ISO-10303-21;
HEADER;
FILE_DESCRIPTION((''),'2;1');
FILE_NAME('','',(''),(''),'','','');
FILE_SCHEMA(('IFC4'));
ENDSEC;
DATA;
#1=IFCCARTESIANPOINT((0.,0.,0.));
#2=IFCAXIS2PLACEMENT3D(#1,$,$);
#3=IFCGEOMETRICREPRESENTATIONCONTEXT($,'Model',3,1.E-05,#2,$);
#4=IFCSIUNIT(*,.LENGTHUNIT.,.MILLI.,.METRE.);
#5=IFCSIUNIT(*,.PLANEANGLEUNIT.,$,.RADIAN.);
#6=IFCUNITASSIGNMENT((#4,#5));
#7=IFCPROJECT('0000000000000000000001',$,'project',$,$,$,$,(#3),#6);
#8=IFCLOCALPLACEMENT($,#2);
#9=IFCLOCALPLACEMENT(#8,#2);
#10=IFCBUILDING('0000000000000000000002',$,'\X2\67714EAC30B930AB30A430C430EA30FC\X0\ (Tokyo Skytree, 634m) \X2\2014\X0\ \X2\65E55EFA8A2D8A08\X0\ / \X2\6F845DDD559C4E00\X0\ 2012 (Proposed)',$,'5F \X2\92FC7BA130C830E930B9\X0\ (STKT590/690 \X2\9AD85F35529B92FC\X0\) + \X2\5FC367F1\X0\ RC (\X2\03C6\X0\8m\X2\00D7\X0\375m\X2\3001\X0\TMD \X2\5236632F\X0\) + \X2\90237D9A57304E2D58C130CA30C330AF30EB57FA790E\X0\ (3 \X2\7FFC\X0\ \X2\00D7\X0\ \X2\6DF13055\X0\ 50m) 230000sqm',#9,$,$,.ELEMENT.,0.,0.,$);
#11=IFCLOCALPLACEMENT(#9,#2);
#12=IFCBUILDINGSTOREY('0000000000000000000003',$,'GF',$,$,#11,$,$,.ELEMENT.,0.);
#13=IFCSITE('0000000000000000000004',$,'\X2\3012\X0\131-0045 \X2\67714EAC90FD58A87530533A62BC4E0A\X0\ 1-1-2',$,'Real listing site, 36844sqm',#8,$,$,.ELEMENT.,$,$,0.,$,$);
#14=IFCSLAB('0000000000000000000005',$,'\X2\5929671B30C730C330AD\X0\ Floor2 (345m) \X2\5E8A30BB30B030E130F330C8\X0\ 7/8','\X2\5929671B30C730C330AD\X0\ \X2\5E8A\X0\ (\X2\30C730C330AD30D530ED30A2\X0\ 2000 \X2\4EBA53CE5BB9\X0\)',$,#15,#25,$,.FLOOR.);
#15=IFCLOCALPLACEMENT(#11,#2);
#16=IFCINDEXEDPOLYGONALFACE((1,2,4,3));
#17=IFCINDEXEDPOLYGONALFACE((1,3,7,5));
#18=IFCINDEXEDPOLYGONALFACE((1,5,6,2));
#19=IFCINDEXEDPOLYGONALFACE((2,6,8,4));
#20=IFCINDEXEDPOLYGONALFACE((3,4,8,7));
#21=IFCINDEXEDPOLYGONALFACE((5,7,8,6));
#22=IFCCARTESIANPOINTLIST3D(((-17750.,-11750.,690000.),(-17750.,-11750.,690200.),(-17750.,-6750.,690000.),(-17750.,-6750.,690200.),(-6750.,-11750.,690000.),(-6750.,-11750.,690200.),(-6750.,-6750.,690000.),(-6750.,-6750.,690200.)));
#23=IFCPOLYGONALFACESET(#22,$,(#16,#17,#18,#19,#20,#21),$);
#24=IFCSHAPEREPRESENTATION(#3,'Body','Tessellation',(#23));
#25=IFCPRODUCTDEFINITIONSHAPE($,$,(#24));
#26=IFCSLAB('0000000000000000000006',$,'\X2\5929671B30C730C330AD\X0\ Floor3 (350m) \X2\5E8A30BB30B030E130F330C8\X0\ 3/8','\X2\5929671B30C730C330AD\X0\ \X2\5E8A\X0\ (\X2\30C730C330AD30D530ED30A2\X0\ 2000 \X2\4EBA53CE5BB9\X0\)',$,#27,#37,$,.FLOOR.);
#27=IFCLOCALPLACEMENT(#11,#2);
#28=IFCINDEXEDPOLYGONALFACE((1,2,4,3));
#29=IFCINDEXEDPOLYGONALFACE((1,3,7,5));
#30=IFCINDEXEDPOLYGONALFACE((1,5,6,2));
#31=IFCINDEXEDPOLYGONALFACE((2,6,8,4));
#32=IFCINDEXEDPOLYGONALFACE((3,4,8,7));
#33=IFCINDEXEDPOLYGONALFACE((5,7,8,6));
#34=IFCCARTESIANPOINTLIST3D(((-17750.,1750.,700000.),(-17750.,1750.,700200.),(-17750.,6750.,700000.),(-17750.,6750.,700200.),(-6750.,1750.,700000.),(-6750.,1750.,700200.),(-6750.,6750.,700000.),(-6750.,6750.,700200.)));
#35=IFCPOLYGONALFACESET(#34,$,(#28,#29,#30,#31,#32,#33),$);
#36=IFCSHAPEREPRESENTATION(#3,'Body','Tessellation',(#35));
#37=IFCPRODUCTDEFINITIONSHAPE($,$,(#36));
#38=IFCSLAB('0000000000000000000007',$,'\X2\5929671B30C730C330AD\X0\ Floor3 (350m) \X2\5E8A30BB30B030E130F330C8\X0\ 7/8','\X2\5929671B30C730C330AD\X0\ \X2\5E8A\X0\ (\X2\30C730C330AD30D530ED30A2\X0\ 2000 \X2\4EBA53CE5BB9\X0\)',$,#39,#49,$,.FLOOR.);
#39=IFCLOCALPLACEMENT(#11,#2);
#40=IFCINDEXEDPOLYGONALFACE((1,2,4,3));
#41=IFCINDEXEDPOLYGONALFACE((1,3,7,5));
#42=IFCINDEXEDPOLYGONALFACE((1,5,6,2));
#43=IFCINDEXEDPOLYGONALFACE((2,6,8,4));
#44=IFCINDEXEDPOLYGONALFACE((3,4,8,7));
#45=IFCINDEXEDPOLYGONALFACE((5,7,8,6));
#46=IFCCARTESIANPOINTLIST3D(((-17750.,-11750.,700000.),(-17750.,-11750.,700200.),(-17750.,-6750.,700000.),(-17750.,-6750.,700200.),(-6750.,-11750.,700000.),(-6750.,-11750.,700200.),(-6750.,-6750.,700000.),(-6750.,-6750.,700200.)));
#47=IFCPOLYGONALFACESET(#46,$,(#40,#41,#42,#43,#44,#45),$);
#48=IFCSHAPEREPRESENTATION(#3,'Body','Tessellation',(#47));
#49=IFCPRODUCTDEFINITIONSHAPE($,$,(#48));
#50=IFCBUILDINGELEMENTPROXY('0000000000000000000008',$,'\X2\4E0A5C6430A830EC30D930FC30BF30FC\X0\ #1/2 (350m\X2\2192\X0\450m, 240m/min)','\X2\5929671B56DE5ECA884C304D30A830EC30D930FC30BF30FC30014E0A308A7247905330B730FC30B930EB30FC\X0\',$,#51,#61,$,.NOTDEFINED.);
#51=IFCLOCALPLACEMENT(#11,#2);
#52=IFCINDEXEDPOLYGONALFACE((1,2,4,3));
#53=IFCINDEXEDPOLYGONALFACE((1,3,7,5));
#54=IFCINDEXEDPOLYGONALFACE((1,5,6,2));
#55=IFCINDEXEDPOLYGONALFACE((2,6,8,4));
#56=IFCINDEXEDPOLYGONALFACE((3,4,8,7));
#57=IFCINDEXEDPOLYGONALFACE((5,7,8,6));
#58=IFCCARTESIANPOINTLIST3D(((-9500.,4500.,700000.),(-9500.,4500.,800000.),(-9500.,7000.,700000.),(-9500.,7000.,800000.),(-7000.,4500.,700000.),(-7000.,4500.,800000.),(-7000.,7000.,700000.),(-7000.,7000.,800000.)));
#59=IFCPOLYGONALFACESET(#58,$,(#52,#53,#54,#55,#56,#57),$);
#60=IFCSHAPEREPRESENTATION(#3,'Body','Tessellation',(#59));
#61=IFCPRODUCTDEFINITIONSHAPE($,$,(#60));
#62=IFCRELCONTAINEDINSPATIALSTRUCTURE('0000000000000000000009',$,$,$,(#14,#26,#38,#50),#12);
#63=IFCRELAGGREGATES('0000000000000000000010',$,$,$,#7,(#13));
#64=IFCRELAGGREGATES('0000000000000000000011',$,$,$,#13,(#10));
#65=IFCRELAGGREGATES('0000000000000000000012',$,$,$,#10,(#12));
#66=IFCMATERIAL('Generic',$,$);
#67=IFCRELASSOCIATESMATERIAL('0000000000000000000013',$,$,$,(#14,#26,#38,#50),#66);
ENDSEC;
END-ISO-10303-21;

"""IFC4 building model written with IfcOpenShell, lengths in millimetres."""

from ifc_helpers import new_model, si_unit, frame, frame_2d, origin, place, context, project, spatial, rectangle, extrude, material, element, save


model = new_model("IFC4")

# Units and contexts
model_context = context("Model", 3, precision=1e-05, world=origin())
ifc_project = project(units=[si_unit("LENGTHUNIT", "METRE", prefix="MILLI"), si_unit("PLANEANGLEUNIT", "RADIAN")], contexts=[model_context])

# Site, building, storey
site_placement = place(None, origin())
site = spatial("IfcSite", under=ifc_project, at=site_placement, Name="〒131-0045 東京都墨田区押上 1-1-2", ObjectType="Real listing site, 36844sqm", CompositionType="ELEMENT", RefElevation=0.0)
building_placement = place(site_placement, origin())
building = spatial("IfcBuilding", under=site, at=building_placement, Name="東京スカイツリー (Tokyo Skytree, 634m) — 日建設計 / 澄川喜一 2012 (Proposed)", ObjectType="5F 鋼管トラス (STKT590/690 高張力鋼) + 心柱 RC (φ8m×375m、TMD 制振) + 連続地中壁ナックル基礎 (3 翼 × 深さ 50m) 230000sqm", CompositionType="ELEMENT", ElevationOfRefHeight=0.0, ElevationOfTerrain=0.0)
storey_placement = place(building_placement, origin())
storey = spatial("IfcBuildingStorey", under=building, at=storey_placement, Name="GF", CompositionType="ELEMENT", Elevation=0.0)

# Shared definitions
ifc_material_1 = material(Name="Generic")

# Slabs
slab_1_placement = place(storey_placement, frame((0.0, -6750.0, 345000.0), x_axis=(0.0, -1.0, 0.0)))
element("IfcSlab", 1, at=slab_1_placement, inside=storey, material=ifc_material_1, Name="天望デッキ Floor2 (345m) 床セグメント 7/8", Description="天望デッキ 床 (デッキフロア 2000 人収容)", PredefinedType="FLOOR", context=model_context, shape_type="SweptSolid", body=[
    extrude(rectangle(XDim=11000.0, YDim=5000.0, at=frame_2d((5500.0, 2500.0))), frame((0.0, -6750.0, 345000.0), x_axis=(0.0, -1.0, 0.0)), (0.0, 0.0, 1.0), 200.0),
])
slab_2_placement = place(storey_placement, frame((0.0, 6750.0, 350000.0), x_axis=(0.0, 1.0, 0.0)))
element("IfcSlab", 2, at=slab_2_placement, inside=storey, material=ifc_material_1, Name="天望デッキ Floor3 (350m) 床セグメント 3/8", Description="天望デッキ 床 (デッキフロア 2000 人収容)", PredefinedType="FLOOR", context=model_context, shape_type="SweptSolid", body=[
    extrude(rectangle(XDim=11000.0, YDim=5000.0, at=frame_2d((5500.0, 2500.0))), frame((0.0, 6750.0, 350000.0), x_axis=(0.0, 1.0, 0.0)), (0.0, 0.0, 1.0), 200.0),
])
slab_3_placement = place(storey_placement, frame((0.0, -6750.0, 350000.0), x_axis=(0.0, -1.0, 0.0)))
element("IfcSlab", 3, at=slab_3_placement, inside=storey, material=ifc_material_1, Name="天望デッキ Floor3 (350m) 床セグメント 7/8", Description="天望デッキ 床 (デッキフロア 2000 人収容)", PredefinedType="FLOOR", context=model_context, shape_type="SweptSolid", body=[
    extrude(rectangle(XDim=11000.0, YDim=5000.0, at=frame_2d((5500.0, 2500.0))), frame((0.0, -6750.0, 350000.0), x_axis=(0.0, -1.0, 0.0)), (0.0, 0.0, 1.0), 200.0),
])

# Building element proxy
proxy_placement = place(storey_placement, frame((0.0, 7000.0, 350000.0), x_axis=(0.0, 1.0, 0.0)))
element("IfcBuildingElementProxy", 4, at=proxy_placement, inside=storey, material=ifc_material_1, Name="上層エレベーター #1/2 (350m→450m, 240m/min)", Description="天望回廊行きエレベーター、上り片道シースルー", PredefinedType="NOTDEFINED", context=model_context, shape_type="SweptSolid", body=[
    extrude(rectangle(XDim=2500.0, YDim=2500.0, at=frame_2d((1250.0, 1250.0))), frame((0.0, 7000.0, 350000.0), x_axis=(0.0, 1.0, 0.0)), (0.0, 0.0, 1.0), 100000.0),
])

save(model, "model.ifc")
